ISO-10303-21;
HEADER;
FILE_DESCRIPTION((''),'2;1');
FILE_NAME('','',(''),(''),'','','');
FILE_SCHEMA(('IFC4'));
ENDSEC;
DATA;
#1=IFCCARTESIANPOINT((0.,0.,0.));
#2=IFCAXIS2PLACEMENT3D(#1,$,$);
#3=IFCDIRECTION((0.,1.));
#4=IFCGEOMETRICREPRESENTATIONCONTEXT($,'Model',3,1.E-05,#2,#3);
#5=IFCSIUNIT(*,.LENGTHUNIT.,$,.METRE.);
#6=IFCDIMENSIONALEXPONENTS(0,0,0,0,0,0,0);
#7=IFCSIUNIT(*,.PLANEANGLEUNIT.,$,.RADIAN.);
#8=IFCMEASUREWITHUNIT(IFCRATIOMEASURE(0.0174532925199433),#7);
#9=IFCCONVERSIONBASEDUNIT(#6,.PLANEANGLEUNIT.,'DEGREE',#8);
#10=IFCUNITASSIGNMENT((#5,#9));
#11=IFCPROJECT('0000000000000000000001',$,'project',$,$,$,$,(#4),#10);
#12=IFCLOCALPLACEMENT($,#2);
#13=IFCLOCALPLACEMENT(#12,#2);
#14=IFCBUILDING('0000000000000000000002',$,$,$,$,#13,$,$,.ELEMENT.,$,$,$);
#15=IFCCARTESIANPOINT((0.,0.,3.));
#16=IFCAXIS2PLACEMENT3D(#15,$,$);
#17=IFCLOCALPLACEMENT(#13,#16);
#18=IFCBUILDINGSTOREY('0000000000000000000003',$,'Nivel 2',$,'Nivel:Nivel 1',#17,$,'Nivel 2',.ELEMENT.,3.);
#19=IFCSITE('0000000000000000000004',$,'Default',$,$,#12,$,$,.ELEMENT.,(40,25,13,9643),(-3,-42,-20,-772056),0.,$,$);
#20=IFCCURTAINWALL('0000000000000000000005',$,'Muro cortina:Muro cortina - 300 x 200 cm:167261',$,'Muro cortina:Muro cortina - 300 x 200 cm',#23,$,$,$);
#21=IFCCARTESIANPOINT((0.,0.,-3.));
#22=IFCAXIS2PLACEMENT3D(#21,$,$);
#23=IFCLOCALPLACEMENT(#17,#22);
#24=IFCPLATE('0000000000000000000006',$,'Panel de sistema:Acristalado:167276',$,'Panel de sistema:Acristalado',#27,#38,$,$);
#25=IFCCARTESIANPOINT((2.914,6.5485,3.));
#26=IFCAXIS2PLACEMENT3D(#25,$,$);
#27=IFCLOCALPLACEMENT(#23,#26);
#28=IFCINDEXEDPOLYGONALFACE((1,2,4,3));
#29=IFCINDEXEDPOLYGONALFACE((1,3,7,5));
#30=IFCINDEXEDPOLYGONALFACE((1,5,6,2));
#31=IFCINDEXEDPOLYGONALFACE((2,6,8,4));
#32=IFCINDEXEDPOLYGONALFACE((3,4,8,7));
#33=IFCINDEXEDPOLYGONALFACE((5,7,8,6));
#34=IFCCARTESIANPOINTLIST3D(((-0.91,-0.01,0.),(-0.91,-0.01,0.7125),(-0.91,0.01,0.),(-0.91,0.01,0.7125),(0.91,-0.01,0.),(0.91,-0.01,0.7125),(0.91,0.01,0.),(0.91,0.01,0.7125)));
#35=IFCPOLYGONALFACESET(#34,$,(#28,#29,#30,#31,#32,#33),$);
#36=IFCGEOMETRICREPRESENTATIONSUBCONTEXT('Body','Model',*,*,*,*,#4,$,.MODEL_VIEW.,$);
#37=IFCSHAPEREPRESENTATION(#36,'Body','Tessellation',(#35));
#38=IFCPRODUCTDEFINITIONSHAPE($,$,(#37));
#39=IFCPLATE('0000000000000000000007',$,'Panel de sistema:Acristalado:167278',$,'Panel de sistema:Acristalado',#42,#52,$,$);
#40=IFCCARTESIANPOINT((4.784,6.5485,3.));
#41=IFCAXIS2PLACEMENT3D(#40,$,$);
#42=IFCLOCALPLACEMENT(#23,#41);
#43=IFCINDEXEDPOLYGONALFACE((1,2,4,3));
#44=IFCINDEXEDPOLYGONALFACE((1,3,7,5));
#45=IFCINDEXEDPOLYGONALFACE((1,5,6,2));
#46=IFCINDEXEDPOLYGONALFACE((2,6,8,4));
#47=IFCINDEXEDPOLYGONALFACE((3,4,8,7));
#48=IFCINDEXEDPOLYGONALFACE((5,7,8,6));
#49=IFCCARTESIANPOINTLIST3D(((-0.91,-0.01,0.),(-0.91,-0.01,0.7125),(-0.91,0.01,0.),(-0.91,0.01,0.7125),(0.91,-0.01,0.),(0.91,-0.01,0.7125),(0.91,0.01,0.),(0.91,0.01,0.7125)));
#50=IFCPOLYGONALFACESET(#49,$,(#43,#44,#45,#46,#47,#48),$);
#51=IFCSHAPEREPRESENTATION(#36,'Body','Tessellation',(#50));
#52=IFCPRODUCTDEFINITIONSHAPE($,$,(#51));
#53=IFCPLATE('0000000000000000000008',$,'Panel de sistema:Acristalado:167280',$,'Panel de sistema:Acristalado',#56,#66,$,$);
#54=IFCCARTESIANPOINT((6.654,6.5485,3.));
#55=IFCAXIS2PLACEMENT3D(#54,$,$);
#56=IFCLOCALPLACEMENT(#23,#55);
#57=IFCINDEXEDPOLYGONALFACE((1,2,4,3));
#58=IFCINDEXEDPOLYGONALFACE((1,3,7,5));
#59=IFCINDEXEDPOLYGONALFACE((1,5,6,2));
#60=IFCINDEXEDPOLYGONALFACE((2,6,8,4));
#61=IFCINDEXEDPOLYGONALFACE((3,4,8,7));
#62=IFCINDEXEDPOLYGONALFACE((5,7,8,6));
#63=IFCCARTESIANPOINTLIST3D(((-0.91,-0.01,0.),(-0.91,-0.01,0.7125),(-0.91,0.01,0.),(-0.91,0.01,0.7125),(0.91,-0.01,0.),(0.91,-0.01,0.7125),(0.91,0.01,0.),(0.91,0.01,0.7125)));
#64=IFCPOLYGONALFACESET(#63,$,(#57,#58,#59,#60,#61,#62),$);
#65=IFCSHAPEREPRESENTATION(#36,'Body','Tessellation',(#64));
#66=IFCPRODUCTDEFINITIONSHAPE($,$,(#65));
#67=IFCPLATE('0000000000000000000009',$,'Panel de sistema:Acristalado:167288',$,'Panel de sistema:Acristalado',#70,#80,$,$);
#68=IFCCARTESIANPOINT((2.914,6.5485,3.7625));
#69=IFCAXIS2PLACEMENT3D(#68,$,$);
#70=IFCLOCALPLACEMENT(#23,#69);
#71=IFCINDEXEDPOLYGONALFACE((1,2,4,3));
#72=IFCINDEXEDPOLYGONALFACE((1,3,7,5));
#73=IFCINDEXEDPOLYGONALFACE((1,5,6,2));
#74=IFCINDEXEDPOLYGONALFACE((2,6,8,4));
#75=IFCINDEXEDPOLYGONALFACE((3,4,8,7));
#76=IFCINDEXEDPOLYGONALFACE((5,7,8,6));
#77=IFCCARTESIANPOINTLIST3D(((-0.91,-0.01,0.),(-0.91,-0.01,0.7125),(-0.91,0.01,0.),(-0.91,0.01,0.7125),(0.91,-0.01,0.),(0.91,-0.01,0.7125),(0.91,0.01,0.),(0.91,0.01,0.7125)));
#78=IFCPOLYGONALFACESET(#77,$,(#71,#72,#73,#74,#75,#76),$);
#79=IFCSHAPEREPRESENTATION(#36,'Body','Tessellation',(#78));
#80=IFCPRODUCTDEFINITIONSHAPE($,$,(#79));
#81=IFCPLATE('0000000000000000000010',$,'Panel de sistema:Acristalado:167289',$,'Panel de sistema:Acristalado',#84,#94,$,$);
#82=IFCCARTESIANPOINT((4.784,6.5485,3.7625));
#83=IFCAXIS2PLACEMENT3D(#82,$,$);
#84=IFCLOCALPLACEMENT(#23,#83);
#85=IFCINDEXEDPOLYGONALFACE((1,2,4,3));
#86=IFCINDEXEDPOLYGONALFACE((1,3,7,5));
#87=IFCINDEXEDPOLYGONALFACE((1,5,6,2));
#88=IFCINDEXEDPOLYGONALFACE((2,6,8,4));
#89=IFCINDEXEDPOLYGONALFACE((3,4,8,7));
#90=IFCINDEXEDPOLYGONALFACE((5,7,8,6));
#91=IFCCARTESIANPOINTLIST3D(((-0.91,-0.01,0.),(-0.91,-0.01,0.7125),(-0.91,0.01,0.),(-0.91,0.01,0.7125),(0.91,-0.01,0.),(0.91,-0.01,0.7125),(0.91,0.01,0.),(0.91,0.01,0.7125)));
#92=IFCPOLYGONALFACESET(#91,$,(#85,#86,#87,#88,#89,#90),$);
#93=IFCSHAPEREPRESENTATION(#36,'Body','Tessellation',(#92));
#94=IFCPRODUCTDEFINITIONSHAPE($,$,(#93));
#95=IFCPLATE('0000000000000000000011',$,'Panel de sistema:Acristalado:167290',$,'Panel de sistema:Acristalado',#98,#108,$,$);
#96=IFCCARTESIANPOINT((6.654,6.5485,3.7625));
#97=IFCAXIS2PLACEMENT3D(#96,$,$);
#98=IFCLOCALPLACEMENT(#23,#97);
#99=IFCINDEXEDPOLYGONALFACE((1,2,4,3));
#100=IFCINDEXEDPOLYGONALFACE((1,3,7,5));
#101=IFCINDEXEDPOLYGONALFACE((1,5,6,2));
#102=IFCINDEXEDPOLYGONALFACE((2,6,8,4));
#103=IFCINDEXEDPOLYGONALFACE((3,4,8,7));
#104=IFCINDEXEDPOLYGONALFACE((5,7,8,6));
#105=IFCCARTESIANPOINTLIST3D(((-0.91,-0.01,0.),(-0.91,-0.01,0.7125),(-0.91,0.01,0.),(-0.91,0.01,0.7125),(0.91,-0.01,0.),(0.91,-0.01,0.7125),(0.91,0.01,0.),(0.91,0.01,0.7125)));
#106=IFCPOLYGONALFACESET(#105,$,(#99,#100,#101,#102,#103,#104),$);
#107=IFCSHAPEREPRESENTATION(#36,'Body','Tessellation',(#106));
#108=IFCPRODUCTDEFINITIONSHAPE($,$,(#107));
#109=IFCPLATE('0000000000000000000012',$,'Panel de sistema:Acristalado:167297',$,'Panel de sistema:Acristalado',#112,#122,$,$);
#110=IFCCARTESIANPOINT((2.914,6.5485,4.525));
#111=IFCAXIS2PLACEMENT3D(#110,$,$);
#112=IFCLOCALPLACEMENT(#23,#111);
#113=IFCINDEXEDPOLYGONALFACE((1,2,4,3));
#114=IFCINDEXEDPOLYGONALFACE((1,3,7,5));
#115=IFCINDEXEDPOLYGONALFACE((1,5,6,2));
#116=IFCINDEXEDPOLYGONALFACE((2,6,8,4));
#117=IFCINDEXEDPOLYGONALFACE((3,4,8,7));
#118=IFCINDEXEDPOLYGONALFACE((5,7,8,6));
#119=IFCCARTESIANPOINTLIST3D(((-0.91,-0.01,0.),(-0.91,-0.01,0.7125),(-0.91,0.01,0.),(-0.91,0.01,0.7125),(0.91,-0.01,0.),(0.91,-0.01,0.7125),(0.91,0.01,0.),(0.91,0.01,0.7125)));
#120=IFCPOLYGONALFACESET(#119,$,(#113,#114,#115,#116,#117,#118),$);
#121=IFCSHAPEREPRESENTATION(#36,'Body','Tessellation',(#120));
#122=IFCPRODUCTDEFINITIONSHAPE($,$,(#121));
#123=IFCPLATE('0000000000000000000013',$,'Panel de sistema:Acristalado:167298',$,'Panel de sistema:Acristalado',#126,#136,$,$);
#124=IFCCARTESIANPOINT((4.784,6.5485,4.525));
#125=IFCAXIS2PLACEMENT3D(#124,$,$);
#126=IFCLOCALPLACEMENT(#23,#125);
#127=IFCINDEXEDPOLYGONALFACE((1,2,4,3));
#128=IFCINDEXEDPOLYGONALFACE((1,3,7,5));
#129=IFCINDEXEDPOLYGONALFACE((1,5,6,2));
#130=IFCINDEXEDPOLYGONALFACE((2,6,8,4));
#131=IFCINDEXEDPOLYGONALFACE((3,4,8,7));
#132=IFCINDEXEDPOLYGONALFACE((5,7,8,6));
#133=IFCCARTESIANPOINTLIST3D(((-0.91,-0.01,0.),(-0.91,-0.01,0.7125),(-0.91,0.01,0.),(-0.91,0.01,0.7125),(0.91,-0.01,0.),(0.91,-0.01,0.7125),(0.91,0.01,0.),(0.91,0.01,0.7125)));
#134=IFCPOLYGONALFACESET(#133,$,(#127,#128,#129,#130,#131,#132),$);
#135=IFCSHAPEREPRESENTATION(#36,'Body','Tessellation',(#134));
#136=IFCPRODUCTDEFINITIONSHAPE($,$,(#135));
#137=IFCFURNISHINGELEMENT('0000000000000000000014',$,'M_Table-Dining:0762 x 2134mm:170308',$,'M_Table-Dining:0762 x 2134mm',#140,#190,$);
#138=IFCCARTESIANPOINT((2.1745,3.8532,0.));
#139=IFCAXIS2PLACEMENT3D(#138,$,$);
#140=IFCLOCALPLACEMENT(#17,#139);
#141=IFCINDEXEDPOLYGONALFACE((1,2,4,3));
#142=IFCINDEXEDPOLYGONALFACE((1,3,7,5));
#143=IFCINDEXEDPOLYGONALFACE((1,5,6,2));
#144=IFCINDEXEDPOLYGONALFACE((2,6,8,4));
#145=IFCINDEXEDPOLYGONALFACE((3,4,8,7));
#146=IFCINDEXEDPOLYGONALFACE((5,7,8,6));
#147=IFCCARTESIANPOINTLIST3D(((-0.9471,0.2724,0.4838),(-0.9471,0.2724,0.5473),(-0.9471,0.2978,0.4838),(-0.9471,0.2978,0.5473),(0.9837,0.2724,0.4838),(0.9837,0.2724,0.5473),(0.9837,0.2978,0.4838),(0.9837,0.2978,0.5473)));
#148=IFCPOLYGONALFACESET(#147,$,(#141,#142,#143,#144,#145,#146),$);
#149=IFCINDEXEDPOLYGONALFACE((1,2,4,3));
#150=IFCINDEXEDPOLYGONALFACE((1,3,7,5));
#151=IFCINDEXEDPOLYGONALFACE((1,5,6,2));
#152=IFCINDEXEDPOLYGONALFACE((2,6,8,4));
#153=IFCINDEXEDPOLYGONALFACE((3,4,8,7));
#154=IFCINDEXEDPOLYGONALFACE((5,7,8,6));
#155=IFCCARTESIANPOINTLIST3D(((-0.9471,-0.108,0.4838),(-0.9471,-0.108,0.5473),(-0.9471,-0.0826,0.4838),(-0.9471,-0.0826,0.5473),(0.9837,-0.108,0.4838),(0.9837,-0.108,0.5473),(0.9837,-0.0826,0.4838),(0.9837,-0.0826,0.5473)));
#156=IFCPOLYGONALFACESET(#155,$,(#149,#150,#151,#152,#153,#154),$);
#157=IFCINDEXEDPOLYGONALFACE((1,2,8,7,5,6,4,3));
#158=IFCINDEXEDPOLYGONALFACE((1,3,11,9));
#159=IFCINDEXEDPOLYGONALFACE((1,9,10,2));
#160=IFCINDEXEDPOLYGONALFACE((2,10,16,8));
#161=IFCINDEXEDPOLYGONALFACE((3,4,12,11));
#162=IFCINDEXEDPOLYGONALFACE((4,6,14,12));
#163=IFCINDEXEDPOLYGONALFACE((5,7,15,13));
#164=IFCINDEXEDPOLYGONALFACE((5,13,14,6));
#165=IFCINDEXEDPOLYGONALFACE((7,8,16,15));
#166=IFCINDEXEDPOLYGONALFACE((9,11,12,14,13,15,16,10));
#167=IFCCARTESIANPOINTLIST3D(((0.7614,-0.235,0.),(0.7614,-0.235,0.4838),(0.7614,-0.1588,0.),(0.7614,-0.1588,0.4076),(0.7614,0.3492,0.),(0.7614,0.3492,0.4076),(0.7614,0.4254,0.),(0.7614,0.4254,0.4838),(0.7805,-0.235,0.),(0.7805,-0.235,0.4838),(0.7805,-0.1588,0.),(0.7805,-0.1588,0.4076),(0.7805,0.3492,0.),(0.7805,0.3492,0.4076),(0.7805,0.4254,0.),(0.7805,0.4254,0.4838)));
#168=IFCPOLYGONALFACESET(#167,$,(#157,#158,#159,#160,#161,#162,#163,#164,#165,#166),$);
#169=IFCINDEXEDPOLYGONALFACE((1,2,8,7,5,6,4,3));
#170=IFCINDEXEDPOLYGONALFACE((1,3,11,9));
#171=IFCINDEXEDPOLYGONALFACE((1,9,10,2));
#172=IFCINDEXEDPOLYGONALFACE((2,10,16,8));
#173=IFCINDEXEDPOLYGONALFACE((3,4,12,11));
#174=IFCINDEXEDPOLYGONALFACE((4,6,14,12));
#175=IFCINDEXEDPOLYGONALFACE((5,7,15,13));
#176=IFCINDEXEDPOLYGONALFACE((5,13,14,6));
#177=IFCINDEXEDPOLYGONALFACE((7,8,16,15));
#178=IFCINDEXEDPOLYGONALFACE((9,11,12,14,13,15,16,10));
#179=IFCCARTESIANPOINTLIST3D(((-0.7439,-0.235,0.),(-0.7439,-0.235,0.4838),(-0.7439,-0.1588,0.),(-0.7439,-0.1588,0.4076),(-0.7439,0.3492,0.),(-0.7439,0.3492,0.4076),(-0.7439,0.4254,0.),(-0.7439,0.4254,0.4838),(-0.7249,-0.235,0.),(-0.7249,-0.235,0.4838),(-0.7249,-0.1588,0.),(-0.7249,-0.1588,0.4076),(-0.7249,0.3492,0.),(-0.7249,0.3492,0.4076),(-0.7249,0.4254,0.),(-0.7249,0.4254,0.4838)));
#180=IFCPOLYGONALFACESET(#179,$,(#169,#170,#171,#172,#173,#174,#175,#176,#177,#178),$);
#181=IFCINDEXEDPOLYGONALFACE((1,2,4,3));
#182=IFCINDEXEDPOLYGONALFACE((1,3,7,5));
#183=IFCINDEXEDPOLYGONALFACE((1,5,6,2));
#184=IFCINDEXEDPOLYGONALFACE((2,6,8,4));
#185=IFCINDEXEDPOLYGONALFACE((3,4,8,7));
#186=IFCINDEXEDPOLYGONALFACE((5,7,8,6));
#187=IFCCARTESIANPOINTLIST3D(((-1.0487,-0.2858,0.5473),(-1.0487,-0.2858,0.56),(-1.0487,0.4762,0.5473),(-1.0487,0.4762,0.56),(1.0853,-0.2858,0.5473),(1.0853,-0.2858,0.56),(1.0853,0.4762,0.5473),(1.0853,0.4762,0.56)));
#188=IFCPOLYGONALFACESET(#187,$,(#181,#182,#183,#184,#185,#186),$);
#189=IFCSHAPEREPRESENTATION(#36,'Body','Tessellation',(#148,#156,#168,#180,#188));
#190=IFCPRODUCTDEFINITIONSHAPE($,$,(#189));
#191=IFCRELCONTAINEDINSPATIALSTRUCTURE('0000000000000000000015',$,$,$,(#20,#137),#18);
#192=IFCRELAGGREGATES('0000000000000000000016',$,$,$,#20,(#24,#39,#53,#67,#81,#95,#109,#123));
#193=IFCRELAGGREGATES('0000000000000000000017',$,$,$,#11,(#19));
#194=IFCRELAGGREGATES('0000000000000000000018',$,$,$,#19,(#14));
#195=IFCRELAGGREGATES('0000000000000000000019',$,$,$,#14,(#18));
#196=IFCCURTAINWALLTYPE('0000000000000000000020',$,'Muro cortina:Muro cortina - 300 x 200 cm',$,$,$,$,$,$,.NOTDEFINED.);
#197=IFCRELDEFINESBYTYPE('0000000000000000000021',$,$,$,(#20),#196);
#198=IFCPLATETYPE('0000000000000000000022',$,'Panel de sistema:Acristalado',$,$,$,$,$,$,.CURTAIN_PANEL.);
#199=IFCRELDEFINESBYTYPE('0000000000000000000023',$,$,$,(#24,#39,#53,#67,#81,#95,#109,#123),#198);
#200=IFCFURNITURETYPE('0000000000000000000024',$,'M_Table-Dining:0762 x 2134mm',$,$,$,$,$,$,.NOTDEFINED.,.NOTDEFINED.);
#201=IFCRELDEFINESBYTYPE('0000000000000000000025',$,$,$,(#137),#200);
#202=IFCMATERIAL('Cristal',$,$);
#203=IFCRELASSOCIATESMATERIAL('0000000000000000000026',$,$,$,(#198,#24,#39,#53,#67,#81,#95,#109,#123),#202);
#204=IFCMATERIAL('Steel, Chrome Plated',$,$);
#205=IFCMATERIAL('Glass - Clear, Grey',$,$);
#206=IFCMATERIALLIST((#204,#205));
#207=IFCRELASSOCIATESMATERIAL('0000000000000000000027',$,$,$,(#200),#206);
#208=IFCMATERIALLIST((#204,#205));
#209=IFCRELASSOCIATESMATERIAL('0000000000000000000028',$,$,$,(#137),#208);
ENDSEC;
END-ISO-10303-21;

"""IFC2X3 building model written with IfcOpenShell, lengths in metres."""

from ifc_helpers import new_model, entity, si_unit, converted_unit, direction, frame, frame_2d, origin, origin_2d_with_axis, place, context, subcontext, project, spatial, polyline, rectangle, outline, extrude, source, transform, mapped, material, material_list, type_object, type_shapes, element, aggregate, save


model = new_model("IFC2X3")

# Units and contexts
model_context = context("Model", 3, precision=1e-05, world=origin(), true_north=direction((0.0, 1.0)))
body_context = subcontext(model_context, "Body", "Model", "MODEL_VIEW")
ifc_project = project(units=[si_unit("LENGTHUNIT", "METRE"), converted_unit("PLANEANGLEUNIT", "DEGREE", entity("IfcRatioMeasure", 0.0174532925199433), si_unit("PLANEANGLEUNIT", "RADIAN"), dimensions=[0, 0, 0, 0, 0, 0, 0])], contexts=[model_context])

# Site, building, storey
site_placement = place(None, origin())
site = spatial("IfcSite", under=ifc_project, at=site_placement, Name="Default", CompositionType="ELEMENT", RefLatitude=(40, 25, 13, 9643), RefLongitude=(-3, -42, -20, -772056), RefElevation=0.0)
building_placement = place(site_placement, origin())
building = spatial("IfcBuilding", under=site, at=building_placement, CompositionType="ELEMENT")
storey_placement = place(building_placement, frame((0.0, 0.0, 3.0)))
storey = spatial("IfcBuildingStorey", under=building, at=storey_placement, Name="Nivel 2", ObjectType="Nivel:Nivel 1", LongName="Nivel 2", CompositionType="ELEMENT", Elevation=3.0)

# Curtain wall, plates
curtain_wall_type = type_object("IfcCurtainWallType", Name="Muro cortina:Muro cortina - 300 x 200 cm", PredefinedType="NOTDEFINED")
curtain_wall_placement = place(storey_placement, frame((0.0, 0.0, -3.0)))
curtain_wall = element("IfcCurtainWall", 1, at=curtain_wall_placement, inside=storey, type_object=curtain_wall_type, Name="Muro cortina:Muro cortina - 300 x 200 cm:167261", ObjectType="Muro cortina:Muro cortina - 300 x 200 cm")
ifc_material_1 = material(Name="Cristal")
plate_type = type_object("IfcPlateType", Name="Panel de sistema:Acristalado", PredefinedType="CURTAIN_PANEL", material=ifc_material_1)
shared_shape_1 = source(origin(), body_context, "Body", "SweptSolid", [
    extrude(rectangle(XDim=0.02, YDim=1.82, at=origin_2d_with_axis()), frame((0.0, 0.0, 0.0), z_axis=(0.0, 0.0, 1.0), x_axis=(0.0, 1.0, 0.0)), (0.0, 0.0, 1.0), 0.7125),
])
type_shapes(plate_type, [shared_shape_1])
plate_1_placement = place(curtain_wall_placement, frame((2.914, 6.5485, 3.0)))
plate_1 = element("IfcPlate", 2, at=plate_1_placement, type_object=plate_type, material=ifc_material_1, Name="Panel de sistema:Acristalado:167276", ObjectType="Panel de sistema:Acristalado", context=body_context, shape_type="MappedRepresentation", body=[
    mapped(shared_shape_1, transform((0.0, 0.0, 0.0), scale=1.0)),
])
plate_2_placement = place(curtain_wall_placement, frame((4.784, 6.5485, 3.0)))
plate_2 = element("IfcPlate", 3, at=plate_2_placement, type_object=plate_type, material=ifc_material_1, Name="Panel de sistema:Acristalado:167278", ObjectType="Panel de sistema:Acristalado", context=body_context, shape_type="MappedRepresentation", body=[
    mapped(shared_shape_1, transform((0.0, 0.0, 0.0), scale=1.0)),
])
plate_3_placement = place(curtain_wall_placement, frame((6.654, 6.5485, 3.0)))
plate_3 = element("IfcPlate", 4, at=plate_3_placement, type_object=plate_type, material=ifc_material_1, Name="Panel de sistema:Acristalado:167280", ObjectType="Panel de sistema:Acristalado", context=body_context, shape_type="MappedRepresentation", body=[
    mapped(shared_shape_1, transform((0.0, 0.0, 0.0), scale=1.0)),
])
plate_4_placement = place(curtain_wall_placement, frame((2.914, 6.5485, 3.7625)))
plate_4 = element("IfcPlate", 5, at=plate_4_placement, type_object=plate_type, material=ifc_material_1, Name="Panel de sistema:Acristalado:167288", ObjectType="Panel de sistema:Acristalado", context=body_context, shape_type="MappedRepresentation", body=[
    mapped(shared_shape_1, transform((0.0, 0.0, 0.0), scale=1.0)),
])
plate_5_placement = place(curtain_wall_placement, frame((4.784, 6.5485, 3.7625)))
plate_5 = element("IfcPlate", 6, at=plate_5_placement, type_object=plate_type, material=ifc_material_1, Name="Panel de sistema:Acristalado:167289", ObjectType="Panel de sistema:Acristalado", context=body_context, shape_type="MappedRepresentation", body=[
    mapped(shared_shape_1, transform((0.0, 0.0, 0.0), scale=1.0)),
])
plate_6_placement = place(curtain_wall_placement, frame((6.654, 6.5485, 3.7625)))
plate_6 = element("IfcPlate", 7, at=plate_6_placement, type_object=plate_type, material=ifc_material_1, Name="Panel de sistema:Acristalado:167290", ObjectType="Panel de sistema:Acristalado", context=body_context, shape_type="MappedRepresentation", body=[
    mapped(shared_shape_1, transform((0.0, 0.0, 0.0), scale=1.0)),
])
plate_7_placement = place(curtain_wall_placement, frame((2.914, 6.5485, 4.525)))
plate_7 = element("IfcPlate", 8, at=plate_7_placement, type_object=plate_type, material=ifc_material_1, Name="Panel de sistema:Acristalado:167297", ObjectType="Panel de sistema:Acristalado", context=body_context, shape_type="MappedRepresentation", body=[
    mapped(shared_shape_1, transform((0.0, 0.0, 0.0), scale=1.0)),
])
plate_8_placement = place(curtain_wall_placement, frame((4.784, 6.5485, 4.525)))
plate_8 = element("IfcPlate", 9, at=plate_8_placement, type_object=plate_type, material=ifc_material_1, Name="Panel de sistema:Acristalado:167298", ObjectType="Panel de sistema:Acristalado", context=body_context, shape_type="MappedRepresentation", body=[
    mapped(shared_shape_1, transform((0.0, 0.0, 0.0), scale=1.0)),
])
aggregate(curtain_wall, [plate_1, plate_2, plate_3, plate_4, plate_5, plate_6, plate_7, plate_8])

# Furnishing element
ifc_material_2 = material(Name="Steel, Chrome Plated")
ifc_material_3 = material(Name="Glass - Clear, Grey")
ifc_material_list_1 = material_list([ifc_material_2, ifc_material_3])
ifc_material_list_2 = material_list([ifc_material_2, ifc_material_3])
furniture_type = type_object("IfcFurnitureType", Name="M_Table-Dining:0762 x 2134mm", material=ifc_material_list_2)
shared_shape_2 = source(origin(), body_context, "Body", "SweptSolid", [
    extrude(rectangle(XDim=1.9308, YDim=0.0254, at=frame_2d((0.0, 0.0), x_axis=(1.0, 0.0))), frame((0.0183, 0.2851, 0.4838), z_axis=(0.0, 0.0, 1.0), x_axis=(-1.0, 0.0, 0.0)), (0.0, 0.0, 1.0), 0.0635),
    extrude(rectangle(XDim=1.9308, YDim=0.0254, at=origin_2d_with_axis()), frame((0.0183, -0.0953, 0.4838), z_axis=(0.0, 0.0, 1.0), x_axis=(-1.0, 0.0, 0.0)), (0.0, 0.0, 1.0), 0.0635),
    extrude(outline(polyline([(-0.2228, -0.3302), (0.2609, -0.3302), (0.2609, 0.3302), (-0.2228, 0.3302), (-0.2228, 0.254), (0.1847, 0.254), (0.1847, -0.254), (-0.2228, -0.254), (-0.2228, -0.3302)])), frame((0.7614, 0.0952, 0.2228), z_axis=(1.0, 0.0, 0.0), x_axis=(0.0, 0.0, 1.0)), (0.0, 0.0, 1.0), 0.0191),
    extrude(outline(polyline([(-0.3302, -0.261), (0.3302, -0.261), (0.3302, 0.2228), (0.254, 0.2228), (0.254, -0.1847), (-0.254, -0.1847), (-0.254, 0.2228), (-0.3302, 0.2228), (-0.3302, -0.261)])), frame((-0.7439, 0.0952, 0.2228), z_axis=(1.0, 0.0, 0.0), x_axis=(0.0, -1.0, 0.0)), (0.0, 0.0, 1.0), 0.0191),
    extrude(rectangle(XDim=2.134, YDim=0.762, at=origin_2d_with_axis()), frame((0.0183, 0.0952, 0.5473), z_axis=(0.0, 0.0, 1.0), x_axis=(-1.0, 0.0, 0.0)), (0.0, 0.0, 1.0), 0.0127),
])
type_shapes(furniture_type, [shared_shape_2])
furnishing_placement = place(storey_placement, frame((2.1745, 3.8532, 0.0)))
element("IfcFurnishingElement", 10, at=furnishing_placement, inside=storey, type_object=furniture_type, material=ifc_material_list_1, Name="M_Table-Dining:0762 x 2134mm:170308", ObjectType="M_Table-Dining:0762 x 2134mm", context=body_context, shape_type="MappedRepresentation", body=[
    mapped(shared_shape_2, transform((0.0, 0.0, 0.0), scale=1.0)),
])

save(model, "model.ifc")
